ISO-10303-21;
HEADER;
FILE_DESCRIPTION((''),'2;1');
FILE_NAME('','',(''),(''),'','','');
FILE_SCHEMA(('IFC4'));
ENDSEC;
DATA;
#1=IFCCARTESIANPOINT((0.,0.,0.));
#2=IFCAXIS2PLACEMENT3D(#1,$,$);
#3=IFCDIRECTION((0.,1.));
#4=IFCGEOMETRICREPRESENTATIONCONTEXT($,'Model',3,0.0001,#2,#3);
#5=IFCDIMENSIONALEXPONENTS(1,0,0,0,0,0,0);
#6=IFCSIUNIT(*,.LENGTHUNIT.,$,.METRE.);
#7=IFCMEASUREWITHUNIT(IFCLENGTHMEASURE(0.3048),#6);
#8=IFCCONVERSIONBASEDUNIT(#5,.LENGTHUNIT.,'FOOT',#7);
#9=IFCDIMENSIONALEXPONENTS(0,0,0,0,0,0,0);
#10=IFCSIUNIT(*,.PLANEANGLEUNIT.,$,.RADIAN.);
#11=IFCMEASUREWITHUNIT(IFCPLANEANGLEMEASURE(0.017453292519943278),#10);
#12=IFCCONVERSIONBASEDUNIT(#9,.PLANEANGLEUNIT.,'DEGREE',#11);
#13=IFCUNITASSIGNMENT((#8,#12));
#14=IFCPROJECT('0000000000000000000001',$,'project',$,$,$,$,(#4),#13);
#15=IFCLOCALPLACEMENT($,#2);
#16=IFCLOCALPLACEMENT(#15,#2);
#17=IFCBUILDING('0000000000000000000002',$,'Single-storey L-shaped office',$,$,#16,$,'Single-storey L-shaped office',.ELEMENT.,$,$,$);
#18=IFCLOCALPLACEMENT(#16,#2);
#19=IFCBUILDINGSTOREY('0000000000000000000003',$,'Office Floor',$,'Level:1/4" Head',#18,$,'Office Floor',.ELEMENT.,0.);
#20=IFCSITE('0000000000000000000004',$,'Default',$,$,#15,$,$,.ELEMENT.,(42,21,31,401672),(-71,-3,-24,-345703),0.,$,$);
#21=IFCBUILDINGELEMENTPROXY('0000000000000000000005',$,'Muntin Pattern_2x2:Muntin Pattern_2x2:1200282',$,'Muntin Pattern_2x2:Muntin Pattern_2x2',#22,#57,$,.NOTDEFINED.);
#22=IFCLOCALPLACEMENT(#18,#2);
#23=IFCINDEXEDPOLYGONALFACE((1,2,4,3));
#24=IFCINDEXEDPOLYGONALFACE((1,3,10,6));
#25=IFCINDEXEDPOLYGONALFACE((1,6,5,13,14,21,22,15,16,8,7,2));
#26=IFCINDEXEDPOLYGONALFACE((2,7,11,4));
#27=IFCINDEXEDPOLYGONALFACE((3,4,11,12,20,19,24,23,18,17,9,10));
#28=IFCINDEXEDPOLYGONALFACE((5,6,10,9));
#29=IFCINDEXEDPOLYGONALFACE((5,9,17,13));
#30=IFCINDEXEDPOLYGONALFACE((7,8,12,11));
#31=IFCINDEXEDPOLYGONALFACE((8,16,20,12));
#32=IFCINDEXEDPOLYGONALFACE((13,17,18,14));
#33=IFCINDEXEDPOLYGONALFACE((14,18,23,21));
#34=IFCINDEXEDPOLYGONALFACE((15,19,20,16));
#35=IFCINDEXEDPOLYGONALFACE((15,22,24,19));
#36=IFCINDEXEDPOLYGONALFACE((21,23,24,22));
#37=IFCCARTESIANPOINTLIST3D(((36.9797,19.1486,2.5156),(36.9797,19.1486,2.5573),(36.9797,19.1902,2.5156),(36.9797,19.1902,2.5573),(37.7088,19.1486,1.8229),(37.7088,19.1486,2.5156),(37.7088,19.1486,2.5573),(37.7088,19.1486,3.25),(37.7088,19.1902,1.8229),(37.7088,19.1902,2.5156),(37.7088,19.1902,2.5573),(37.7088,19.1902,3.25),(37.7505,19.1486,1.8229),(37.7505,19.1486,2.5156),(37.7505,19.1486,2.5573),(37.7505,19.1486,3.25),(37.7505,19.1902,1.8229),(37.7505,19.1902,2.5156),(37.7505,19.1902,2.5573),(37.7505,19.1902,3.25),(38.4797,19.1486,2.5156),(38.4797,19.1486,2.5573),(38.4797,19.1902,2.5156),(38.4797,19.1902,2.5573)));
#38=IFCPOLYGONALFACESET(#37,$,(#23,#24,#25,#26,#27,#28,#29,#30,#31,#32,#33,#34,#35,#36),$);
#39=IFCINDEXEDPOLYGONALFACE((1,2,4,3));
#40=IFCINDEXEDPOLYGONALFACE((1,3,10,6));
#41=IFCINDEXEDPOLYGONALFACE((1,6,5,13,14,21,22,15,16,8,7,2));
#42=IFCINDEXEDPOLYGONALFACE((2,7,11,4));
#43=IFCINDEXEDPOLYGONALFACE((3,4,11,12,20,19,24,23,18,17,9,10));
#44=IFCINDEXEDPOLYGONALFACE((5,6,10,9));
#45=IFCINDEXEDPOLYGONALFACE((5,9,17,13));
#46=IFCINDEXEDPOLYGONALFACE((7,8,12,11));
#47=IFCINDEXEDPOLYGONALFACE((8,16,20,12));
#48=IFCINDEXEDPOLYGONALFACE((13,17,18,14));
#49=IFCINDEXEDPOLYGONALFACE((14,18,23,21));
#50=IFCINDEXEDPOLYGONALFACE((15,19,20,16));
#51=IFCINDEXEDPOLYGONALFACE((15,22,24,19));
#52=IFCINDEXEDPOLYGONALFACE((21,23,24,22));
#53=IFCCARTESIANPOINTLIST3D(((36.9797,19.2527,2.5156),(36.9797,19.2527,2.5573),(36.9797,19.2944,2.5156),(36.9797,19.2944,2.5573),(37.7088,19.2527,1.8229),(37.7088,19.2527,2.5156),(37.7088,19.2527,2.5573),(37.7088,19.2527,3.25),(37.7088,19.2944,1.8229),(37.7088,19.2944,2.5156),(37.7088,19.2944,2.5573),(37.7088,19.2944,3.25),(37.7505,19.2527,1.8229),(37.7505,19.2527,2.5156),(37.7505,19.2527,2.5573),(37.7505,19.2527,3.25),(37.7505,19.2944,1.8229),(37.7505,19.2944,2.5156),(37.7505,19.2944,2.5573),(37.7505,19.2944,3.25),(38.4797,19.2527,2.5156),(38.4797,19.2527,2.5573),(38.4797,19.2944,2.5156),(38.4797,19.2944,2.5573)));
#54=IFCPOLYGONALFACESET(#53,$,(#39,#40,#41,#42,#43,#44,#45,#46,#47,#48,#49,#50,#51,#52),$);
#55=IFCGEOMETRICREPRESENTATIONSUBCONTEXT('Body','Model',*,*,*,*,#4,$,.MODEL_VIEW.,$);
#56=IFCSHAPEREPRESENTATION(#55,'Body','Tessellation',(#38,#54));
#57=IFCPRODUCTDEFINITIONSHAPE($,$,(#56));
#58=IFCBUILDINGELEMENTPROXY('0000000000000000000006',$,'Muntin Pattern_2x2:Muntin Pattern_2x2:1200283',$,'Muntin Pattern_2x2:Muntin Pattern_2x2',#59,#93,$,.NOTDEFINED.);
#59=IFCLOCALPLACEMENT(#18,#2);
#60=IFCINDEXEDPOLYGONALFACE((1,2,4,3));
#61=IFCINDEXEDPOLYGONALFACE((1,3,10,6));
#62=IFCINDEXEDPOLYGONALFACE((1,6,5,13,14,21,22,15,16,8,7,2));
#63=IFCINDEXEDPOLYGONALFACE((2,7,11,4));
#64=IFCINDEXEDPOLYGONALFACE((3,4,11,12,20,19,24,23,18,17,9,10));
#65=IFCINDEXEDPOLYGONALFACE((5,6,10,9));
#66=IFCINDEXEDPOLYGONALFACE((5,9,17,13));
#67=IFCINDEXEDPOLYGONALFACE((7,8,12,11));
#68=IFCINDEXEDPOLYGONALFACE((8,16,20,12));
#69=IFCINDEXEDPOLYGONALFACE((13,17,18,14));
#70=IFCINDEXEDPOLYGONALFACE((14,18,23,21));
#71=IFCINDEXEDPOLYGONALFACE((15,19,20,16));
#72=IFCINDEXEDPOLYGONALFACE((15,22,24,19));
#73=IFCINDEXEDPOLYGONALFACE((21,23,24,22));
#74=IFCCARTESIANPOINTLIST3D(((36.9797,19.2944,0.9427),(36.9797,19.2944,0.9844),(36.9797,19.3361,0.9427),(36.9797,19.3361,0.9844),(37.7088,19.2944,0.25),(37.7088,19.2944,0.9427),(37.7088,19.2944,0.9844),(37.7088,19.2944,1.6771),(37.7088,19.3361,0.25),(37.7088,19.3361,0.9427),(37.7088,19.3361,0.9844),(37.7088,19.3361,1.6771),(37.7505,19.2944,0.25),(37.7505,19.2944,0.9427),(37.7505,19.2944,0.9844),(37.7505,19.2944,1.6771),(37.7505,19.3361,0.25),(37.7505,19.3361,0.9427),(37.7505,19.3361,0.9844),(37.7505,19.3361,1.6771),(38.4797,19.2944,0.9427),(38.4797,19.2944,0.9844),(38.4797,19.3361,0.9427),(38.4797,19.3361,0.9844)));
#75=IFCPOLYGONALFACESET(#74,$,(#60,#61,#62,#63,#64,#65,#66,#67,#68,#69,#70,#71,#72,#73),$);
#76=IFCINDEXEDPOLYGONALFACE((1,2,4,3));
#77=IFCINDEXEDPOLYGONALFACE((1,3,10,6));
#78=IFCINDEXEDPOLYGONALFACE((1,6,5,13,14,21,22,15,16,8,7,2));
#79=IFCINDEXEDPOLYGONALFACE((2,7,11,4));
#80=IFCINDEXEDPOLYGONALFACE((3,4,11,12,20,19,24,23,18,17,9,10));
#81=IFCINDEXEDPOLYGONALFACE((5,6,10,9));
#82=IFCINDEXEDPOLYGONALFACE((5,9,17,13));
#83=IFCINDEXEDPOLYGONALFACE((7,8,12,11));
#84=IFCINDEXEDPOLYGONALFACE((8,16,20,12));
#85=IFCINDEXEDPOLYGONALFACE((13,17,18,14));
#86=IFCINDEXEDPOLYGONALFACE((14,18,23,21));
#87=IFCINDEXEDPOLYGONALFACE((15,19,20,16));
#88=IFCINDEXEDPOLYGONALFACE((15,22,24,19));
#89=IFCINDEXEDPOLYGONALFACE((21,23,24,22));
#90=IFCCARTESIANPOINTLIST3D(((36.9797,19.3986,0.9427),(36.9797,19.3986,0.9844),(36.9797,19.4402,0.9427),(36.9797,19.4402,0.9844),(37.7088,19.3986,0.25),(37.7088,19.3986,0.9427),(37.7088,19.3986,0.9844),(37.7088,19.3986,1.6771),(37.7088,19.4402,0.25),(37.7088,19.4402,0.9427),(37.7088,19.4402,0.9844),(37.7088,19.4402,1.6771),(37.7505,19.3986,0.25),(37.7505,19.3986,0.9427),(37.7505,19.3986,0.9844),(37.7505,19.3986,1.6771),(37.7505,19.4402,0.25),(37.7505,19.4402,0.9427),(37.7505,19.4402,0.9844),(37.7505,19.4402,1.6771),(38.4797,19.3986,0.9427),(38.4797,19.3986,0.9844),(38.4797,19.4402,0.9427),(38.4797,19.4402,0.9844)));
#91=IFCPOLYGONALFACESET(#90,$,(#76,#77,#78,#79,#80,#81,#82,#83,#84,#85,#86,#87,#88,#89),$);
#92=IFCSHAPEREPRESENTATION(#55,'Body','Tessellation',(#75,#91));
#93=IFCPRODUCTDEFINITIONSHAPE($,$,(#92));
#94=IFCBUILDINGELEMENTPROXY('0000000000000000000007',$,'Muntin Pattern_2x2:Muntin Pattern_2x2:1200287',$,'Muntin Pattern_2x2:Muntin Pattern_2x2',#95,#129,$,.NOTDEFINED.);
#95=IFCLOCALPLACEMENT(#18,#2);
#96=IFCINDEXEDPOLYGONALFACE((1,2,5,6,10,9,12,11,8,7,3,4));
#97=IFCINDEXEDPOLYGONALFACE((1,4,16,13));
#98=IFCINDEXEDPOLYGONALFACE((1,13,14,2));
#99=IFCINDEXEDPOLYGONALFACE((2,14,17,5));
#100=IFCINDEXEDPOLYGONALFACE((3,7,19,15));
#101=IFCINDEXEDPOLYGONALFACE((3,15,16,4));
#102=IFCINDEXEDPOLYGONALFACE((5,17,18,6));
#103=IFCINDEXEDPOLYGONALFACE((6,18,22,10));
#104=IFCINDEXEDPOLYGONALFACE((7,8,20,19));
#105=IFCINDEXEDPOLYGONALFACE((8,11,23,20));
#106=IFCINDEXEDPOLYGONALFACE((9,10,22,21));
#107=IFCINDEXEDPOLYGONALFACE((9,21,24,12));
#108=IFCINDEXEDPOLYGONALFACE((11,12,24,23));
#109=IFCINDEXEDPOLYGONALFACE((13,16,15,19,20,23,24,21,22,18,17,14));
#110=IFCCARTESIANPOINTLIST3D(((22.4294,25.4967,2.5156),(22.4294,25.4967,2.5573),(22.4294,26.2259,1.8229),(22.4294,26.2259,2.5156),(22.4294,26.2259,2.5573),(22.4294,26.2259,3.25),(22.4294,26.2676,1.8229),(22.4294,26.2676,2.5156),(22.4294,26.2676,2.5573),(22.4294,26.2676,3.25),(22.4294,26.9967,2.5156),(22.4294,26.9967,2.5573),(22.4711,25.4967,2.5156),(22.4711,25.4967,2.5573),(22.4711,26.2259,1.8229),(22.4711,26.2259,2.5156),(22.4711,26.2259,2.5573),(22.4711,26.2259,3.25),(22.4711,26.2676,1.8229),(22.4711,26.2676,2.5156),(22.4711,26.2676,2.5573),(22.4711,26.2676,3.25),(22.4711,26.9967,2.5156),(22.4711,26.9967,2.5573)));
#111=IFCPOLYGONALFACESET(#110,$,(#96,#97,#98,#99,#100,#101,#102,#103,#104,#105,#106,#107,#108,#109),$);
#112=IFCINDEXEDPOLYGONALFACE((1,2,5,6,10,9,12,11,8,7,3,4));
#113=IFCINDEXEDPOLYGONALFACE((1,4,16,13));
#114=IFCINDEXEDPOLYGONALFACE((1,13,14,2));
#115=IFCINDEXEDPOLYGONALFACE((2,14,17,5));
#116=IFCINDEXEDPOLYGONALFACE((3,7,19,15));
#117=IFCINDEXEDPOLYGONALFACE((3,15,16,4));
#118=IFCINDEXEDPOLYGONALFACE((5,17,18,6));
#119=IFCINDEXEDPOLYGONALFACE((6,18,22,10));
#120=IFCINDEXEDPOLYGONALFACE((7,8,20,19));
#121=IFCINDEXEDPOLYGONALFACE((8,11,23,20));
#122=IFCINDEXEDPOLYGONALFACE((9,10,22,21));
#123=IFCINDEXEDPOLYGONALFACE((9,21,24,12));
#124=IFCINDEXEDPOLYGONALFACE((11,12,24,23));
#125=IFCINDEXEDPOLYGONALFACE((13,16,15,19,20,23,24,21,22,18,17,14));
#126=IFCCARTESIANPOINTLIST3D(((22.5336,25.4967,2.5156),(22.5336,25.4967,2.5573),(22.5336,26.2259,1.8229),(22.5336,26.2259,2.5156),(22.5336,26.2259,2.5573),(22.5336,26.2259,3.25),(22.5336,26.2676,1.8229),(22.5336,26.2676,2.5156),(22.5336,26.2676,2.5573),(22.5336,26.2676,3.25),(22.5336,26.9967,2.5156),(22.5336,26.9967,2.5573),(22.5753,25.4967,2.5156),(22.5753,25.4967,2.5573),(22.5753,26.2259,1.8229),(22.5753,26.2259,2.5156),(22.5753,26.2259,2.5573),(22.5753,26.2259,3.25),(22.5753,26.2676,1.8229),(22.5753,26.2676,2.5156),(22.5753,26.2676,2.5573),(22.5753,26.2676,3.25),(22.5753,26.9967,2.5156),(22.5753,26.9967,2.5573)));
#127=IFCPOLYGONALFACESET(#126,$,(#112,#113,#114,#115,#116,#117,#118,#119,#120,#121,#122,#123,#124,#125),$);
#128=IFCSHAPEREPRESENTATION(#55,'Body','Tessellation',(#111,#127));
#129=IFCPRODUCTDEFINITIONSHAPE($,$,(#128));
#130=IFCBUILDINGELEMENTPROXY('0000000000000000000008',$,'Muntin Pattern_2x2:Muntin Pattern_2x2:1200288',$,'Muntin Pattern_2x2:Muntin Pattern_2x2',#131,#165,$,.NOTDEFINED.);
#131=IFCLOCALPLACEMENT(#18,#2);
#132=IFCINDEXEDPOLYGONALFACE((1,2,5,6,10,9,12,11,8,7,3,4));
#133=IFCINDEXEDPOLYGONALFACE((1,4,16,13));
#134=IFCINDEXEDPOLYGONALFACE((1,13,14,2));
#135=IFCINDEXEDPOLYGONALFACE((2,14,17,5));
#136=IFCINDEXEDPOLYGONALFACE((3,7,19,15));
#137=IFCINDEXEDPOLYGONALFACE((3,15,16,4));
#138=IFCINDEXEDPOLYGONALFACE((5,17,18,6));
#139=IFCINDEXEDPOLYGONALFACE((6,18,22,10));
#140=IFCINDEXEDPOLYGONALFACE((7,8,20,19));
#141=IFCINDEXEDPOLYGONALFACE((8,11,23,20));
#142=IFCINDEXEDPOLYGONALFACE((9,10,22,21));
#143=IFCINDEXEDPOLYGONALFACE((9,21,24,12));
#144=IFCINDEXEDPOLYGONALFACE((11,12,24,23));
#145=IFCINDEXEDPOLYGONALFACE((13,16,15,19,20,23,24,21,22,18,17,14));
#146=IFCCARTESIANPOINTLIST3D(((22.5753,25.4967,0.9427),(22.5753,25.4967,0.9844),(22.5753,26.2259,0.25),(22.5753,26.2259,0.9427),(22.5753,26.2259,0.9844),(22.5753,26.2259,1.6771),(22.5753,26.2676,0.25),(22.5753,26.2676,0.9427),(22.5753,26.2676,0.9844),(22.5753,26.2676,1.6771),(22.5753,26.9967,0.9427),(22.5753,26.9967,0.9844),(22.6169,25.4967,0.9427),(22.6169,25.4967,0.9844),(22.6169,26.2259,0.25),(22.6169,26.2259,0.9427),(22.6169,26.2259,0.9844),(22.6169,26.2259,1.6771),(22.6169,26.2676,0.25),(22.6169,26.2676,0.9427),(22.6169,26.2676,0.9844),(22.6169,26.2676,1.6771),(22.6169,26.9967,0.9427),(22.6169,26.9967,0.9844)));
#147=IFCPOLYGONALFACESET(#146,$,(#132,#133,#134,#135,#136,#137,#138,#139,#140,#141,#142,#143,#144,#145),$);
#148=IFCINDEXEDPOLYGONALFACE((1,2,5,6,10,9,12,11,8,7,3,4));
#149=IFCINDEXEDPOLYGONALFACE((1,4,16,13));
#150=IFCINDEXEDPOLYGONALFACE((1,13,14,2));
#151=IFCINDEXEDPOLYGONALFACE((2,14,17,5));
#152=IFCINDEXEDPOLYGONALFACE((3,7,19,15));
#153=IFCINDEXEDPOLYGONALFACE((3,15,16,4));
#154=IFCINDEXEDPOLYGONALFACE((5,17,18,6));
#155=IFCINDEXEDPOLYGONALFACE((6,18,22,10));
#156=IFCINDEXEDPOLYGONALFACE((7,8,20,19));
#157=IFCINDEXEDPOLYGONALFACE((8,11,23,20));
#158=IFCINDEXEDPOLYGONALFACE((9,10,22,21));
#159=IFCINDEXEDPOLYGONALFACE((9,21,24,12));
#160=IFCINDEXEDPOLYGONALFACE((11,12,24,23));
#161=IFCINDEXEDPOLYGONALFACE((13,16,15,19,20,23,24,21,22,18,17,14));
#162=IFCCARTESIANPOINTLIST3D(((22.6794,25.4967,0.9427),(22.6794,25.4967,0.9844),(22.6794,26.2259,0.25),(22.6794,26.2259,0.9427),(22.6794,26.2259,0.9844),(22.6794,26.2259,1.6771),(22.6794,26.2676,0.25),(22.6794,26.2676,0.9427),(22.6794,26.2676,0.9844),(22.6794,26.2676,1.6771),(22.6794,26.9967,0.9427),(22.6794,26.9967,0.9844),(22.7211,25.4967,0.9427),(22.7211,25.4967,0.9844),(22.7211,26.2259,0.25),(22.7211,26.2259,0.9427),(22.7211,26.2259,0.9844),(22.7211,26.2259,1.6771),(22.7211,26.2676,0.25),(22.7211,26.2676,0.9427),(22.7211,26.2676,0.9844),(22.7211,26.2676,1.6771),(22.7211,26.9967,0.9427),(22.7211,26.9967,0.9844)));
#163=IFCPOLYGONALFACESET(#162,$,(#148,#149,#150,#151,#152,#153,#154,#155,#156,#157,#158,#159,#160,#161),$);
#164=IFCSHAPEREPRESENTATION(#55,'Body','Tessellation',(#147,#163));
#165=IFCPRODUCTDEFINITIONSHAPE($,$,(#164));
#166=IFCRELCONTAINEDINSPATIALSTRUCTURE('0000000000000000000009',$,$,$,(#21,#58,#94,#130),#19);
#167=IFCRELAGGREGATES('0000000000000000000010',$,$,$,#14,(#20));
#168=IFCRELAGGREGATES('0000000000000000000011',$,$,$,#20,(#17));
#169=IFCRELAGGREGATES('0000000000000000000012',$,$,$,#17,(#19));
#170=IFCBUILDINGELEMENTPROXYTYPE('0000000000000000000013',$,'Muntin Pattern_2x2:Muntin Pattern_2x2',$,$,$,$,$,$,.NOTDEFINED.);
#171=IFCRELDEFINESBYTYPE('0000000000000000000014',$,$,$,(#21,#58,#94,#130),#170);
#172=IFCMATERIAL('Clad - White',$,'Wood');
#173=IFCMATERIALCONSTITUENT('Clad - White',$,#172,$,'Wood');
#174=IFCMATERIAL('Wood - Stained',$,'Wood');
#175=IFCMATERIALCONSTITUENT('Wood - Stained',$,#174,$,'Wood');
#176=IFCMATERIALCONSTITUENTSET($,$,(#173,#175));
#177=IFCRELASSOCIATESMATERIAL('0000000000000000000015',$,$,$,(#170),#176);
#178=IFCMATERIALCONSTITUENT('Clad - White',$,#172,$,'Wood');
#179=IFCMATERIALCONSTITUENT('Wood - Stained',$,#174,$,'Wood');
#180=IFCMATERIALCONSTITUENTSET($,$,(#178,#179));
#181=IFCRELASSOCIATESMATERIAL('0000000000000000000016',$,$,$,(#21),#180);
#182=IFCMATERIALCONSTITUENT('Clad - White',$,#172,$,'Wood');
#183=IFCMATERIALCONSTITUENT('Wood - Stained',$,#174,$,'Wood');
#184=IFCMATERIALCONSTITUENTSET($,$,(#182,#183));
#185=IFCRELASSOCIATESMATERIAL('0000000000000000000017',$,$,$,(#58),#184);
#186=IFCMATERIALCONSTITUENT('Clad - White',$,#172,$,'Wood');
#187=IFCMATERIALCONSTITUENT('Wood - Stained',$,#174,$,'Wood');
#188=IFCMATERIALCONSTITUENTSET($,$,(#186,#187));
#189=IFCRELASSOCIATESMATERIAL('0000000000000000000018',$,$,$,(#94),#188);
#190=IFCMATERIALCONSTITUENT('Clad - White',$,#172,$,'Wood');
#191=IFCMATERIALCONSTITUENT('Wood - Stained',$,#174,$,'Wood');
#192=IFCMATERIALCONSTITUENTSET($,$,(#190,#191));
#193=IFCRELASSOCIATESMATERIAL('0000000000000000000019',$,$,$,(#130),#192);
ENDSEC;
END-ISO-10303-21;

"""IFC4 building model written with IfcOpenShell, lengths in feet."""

from ifc_helpers import new_model, entity, si_unit, converted_unit, direction, frame, origin, place, context, subcontext, project, spatial, indexed_curve, outline, extrude, source, transform, mapped, material, constituent, constituent_set, type_object, type_shapes, element, save


model = new_model("IFC4")

# Units and contexts
model_context = context("Model", 3, precision=0.0001, world=origin(), true_north=direction((0.0, 1.0)))
body_context = subcontext(model_context, "Body", "Model", "MODEL_VIEW")
ifc_project = project(units=[converted_unit("LENGTHUNIT", "FOOT", entity("IfcLengthMeasure", 0.3048), si_unit("LENGTHUNIT", "METRE"), dimensions=[1, 0, 0, 0, 0, 0, 0]), converted_unit("PLANEANGLEUNIT", "DEGREE", entity("IfcPlaneAngleMeasure", 0.017453292519943278), si_unit("PLANEANGLEUNIT", "RADIAN"), dimensions=[0, 0, 0, 0, 0, 0, 0])], contexts=[model_context])

# Site, building, storey
site_placement = place(None, origin())
site = spatial("IfcSite", under=ifc_project, at=site_placement, Name="Default", CompositionType="ELEMENT", RefLatitude=(42, 21, 31, 401672), RefLongitude=(-71, -3, -24, -345703), RefElevation=0.0)
building_placement = place(site_placement, origin())
building = spatial("IfcBuilding", under=site, at=building_placement, Name="Single-storey L-shaped office", LongName="Single-storey L-shaped office", CompositionType="ELEMENT")
storey_placement = place(building_placement, origin())
storey = spatial("IfcBuildingStorey", under=building, at=storey_placement, Name="Office Floor", ObjectType="Level:1/4\" Head", LongName="Office Floor", CompositionType="ELEMENT", Elevation=0.0)

# Shared definitions
ifc_material_1 = material(Name="Wood - Stained", Category="Wood")

# Building element proxies
ifc_material_2 = material(Name="Clad - White", Category="Wood")
ifc_constituent_1 = constituent(ifc_material_2, Name="Clad - White", Category="Wood")
ifc_constituent_2 = constituent(ifc_material_1, Name="Wood - Stained", Category="Wood")
ifc_constituent_set_1 = constituent_set(constituents=[ifc_constituent_1, ifc_constituent_2])
building_element_proxy_type_1 = type_object("IfcBuildingElementProxyType", Name="Muntin Pattern_2x2:Muntin Pattern_2x2", PredefinedType="NOTDEFINED", material=ifc_constituent_set_1)
shared_shape_1 = source(origin(), body_context, "Body", "SweptSolid", [
    extrude(outline(indexed_curve([(0.0208, -0.0208), (0.7135, -0.0208), (0.7135, 0.0208), (0.0208, 0.0208), (0.0208, 0.75), (-0.0208, 0.75), (-0.0208, 0.0208), (-0.7135, 0.0208), (-0.7135, -0.0208), (-0.0208, -0.0208), (-0.0208, -0.75), (0.0208, -0.75), (0.0208, -0.0208)], self_intersect=False)), frame((0.0, 0.0312, 0.7135), z_axis=(0.0, 1.0, 0.0), x_axis=(0.0, 0.0, 1.0)), (0.0, 0.0, 1.0), 0.0417),
    extrude(outline(indexed_curve([(0.0208, -0.0208), (0.7135, -0.0208), (0.7135, 0.0208), (0.0208, 0.0208), (0.0208, 0.75), (-0.0208, 0.75), (-0.0208, 0.0208), (-0.7135, 0.0208), (-0.7135, -0.0208), (-0.0208, -0.0208), (-0.0208, -0.75), (0.0208, -0.75), (0.0208, -0.0208)], self_intersect=False)), frame((0.0, -0.0729, 0.7135), z_axis=(0.0, 1.0, 0.0), x_axis=(0.0, 0.0, 1.0)), (0.0, 0.0, 1.0), 0.0417),
])
type_shapes(building_element_proxy_type_1, [shared_shape_1])
ifc_constituent_3 = constituent(ifc_material_2, Name="Clad - White", Category="Wood")
ifc_constituent_4 = constituent(ifc_material_1, Name="Wood - Stained", Category="Wood")
ifc_constituent_set_2 = constituent_set(constituents=[ifc_constituent_3, ifc_constituent_4])
proxy_1_placement = place(storey_placement, frame((37.7297, 19.2215, 1.8229), z_axis=(0.0, 0.0, 1.0), x_axis=(-1.0, 0.0, 0.0)))
element("IfcBuildingElementProxy", 1, at=proxy_1_placement, inside=storey, type_object=building_element_proxy_type_1, material=ifc_constituent_set_2, Name="Muntin Pattern_2x2:Muntin Pattern_2x2:1200282", ObjectType="Muntin Pattern_2x2:Muntin Pattern_2x2", PredefinedType="NOTDEFINED", context=body_context, shape_type="MappedRepresentation", body=[
    mapped(shared_shape_1, transform((0.0, 0.0, 0.0), scale=1.0)),
])
ifc_constituent_5 = constituent(ifc_material_2, Name="Clad - White", Category="Wood")
ifc_constituent_6 = constituent(ifc_material_1, Name="Wood - Stained", Category="Wood")
ifc_constituent_set_3 = constituent_set(constituents=[ifc_constituent_5, ifc_constituent_6])
proxy_2_placement = place(storey_placement, frame((37.7297, 19.3673, 0.25), z_axis=(0.0, 0.0, 1.0), x_axis=(-1.0, 0.0, 0.0)))
element("IfcBuildingElementProxy", 2, at=proxy_2_placement, inside=storey, type_object=building_element_proxy_type_1, material=ifc_constituent_set_3, Name="Muntin Pattern_2x2:Muntin Pattern_2x2:1200283", ObjectType="Muntin Pattern_2x2:Muntin Pattern_2x2", PredefinedType="NOTDEFINED", context=body_context, shape_type="MappedRepresentation", body=[
    mapped(shared_shape_1, transform((0.0, 0.0, 0.0), scale=1.0)),
])
ifc_constituent_7 = constituent(ifc_material_2, Name="Clad - White", Category="Wood")
ifc_constituent_8 = constituent(ifc_material_1, Name="Wood - Stained", Category="Wood")
ifc_constituent_set_4 = constituent_set(constituents=[ifc_constituent_7, ifc_constituent_8])
proxy_3_placement = place(storey_placement, frame((22.5023, 26.2467, 1.8229), z_axis=(0.0, 0.0, 1.0), x_axis=(0.0, 1.0, 0.0)))
element("IfcBuildingElementProxy", 3, at=proxy_3_placement, inside=storey, type_object=building_element_proxy_type_1, material=ifc_constituent_set_4, Name="Muntin Pattern_2x2:Muntin Pattern_2x2:1200287", ObjectType="Muntin Pattern_2x2:Muntin Pattern_2x2", PredefinedType="NOTDEFINED", context=body_context, shape_type="MappedRepresentation", body=[
    mapped(shared_shape_1, transform((0.0, 0.0, 0.0), scale=1.0)),
])
ifc_constituent_9 = constituent(ifc_material_2, Name="Clad - White", Category="Wood")
ifc_constituent_10 = constituent(ifc_material_1, Name="Wood - Stained", Category="Wood")
ifc_constituent_set_5 = constituent_set(constituents=[ifc_constituent_9, ifc_constituent_10])
proxy_4_placement = place(storey_placement, frame((22.6482, 26.2467, 0.25), z_axis=(0.0, 0.0, 1.0), x_axis=(0.0, 1.0, 0.0)))
element("IfcBuildingElementProxy", 4, at=proxy_4_placement, inside=storey, type_object=building_element_proxy_type_1, material=ifc_constituent_set_5, Name="Muntin Pattern_2x2:Muntin Pattern_2x2:1200288", ObjectType="Muntin Pattern_2x2:Muntin Pattern_2x2", PredefinedType="NOTDEFINED", context=body_context, shape_type="MappedRepresentation", body=[
    mapped(shared_shape_1, transform((0.0, 0.0, 0.0), scale=1.0)),
])

save(model, "model.ifc")
